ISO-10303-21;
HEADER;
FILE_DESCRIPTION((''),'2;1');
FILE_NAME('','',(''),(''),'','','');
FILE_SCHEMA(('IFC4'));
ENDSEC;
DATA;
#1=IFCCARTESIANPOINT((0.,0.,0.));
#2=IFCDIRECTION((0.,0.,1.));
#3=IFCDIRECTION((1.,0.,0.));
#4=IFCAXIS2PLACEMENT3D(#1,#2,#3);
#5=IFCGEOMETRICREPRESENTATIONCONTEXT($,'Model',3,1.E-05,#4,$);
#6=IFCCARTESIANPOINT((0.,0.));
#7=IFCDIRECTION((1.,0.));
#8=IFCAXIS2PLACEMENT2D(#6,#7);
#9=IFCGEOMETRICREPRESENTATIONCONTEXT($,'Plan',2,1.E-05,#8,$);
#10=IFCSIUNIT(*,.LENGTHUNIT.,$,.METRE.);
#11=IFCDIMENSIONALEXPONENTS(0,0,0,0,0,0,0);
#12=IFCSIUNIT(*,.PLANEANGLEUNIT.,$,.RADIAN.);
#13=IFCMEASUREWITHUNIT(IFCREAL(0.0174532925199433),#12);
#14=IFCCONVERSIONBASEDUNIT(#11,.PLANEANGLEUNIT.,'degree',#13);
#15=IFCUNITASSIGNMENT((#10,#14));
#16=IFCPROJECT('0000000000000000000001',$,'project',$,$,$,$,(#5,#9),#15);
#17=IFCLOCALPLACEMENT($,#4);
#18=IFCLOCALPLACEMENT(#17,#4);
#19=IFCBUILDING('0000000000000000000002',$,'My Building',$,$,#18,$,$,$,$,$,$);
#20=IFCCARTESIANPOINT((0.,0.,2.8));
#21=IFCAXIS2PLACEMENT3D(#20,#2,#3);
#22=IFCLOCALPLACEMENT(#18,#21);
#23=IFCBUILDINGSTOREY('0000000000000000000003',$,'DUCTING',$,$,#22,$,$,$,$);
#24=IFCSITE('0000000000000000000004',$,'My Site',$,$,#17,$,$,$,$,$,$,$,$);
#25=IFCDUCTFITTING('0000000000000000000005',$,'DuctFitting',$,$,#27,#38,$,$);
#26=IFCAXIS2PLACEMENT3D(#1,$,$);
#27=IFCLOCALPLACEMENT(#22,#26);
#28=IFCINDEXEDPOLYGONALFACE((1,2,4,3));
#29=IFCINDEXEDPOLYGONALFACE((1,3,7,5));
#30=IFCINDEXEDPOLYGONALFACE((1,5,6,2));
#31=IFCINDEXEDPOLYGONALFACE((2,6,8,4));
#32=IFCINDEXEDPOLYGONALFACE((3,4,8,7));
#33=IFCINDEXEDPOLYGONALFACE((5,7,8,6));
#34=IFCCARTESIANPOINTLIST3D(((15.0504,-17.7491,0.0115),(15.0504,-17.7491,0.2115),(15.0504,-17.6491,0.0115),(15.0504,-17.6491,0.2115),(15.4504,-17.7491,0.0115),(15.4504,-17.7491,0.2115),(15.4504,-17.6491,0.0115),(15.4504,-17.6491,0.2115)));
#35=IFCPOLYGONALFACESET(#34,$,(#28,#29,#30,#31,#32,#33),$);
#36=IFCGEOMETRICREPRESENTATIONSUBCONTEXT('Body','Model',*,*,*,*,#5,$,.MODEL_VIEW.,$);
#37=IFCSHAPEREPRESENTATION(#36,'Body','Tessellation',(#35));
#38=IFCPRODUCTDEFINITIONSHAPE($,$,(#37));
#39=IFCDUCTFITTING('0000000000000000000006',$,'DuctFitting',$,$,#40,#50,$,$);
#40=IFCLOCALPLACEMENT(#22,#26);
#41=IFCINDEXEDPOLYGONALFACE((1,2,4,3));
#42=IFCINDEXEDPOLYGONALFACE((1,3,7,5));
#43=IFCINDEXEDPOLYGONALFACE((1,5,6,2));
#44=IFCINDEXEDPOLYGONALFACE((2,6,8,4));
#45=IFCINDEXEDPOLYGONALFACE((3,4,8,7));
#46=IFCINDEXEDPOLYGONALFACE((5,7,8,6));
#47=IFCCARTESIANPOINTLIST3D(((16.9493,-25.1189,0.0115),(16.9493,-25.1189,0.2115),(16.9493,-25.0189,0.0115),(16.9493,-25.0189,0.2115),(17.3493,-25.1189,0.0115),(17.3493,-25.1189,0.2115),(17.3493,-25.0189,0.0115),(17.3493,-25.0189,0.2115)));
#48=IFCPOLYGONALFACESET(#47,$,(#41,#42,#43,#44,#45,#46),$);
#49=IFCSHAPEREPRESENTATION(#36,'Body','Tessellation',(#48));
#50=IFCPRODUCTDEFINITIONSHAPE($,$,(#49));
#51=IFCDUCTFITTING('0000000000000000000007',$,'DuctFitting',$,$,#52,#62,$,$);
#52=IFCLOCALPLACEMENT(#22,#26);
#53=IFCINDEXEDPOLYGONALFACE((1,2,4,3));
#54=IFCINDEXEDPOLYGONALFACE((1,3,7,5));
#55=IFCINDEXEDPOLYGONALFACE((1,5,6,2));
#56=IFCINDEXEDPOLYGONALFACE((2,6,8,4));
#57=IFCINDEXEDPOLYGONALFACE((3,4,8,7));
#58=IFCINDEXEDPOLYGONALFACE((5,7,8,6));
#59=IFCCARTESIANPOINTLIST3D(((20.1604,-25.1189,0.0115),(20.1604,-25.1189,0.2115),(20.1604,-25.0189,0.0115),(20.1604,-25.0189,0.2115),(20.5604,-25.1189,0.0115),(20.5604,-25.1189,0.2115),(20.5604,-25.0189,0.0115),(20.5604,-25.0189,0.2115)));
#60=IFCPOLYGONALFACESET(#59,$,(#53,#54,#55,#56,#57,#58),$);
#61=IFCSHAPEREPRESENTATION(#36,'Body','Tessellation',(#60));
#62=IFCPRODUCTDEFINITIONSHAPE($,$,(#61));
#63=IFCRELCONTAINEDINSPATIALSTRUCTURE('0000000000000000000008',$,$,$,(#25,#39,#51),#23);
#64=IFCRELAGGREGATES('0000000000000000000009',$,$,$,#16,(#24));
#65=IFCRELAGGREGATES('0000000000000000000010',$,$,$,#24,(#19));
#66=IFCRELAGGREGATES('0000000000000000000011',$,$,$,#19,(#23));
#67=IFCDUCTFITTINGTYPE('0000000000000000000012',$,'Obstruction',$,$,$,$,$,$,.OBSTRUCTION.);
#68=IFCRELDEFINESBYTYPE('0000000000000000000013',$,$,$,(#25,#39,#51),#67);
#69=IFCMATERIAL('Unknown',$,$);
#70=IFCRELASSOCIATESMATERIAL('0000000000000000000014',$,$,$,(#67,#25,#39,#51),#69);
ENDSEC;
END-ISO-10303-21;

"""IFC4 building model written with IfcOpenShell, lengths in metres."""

from ifc_helpers import new_model, entity, si_unit, converted_unit, frame, origin_with_axes, origin_2d_with_axis, place, context, subcontext, project, spatial, rectangle, extrude, material, material_profile, profile_set, profile_usage, type_object, element, save


model = new_model("IFC4")

# Units and contexts
model_context = context("Model", 3, precision=1e-05, world=origin_with_axes())
plan_context = context("Plan", 2, precision=1e-05, world=origin_2d_with_axis())
body_context = subcontext(model_context, "Body", "Model", "MODEL_VIEW")
ifc_project = project(units=[si_unit("LENGTHUNIT", "METRE"), converted_unit("PLANEANGLEUNIT", "degree", entity("IfcReal", 0.0174532925199433), si_unit("PLANEANGLEUNIT", "RADIAN"), dimensions=[0, 0, 0, 0, 0, 0, 0])], contexts=[model_context, plan_context])

# Site, building, storey
site_placement = place(None, origin_with_axes())
site = spatial("IfcSite", under=ifc_project, at=site_placement, Name="My Site")
building_placement = place(site_placement, origin_with_axes())
building = spatial("IfcBuilding", under=site, at=building_placement, Name="My Building")
storey_placement = place(building_placement, frame((0.0, 0.0, 2.8), z_axis=(0.0, 0.0, 1.0), x_axis=(1.0, 0.0, 0.0)))
storey = spatial("IfcBuildingStorey", under=building, at=storey_placement, Name="DUCTING")

# Shared definitions
ifc_material = material(Name="Unknown")

# Duct fittings
ifc_material_profile_1 = material_profile(ifc_material, rectangle(XDim=0.4, YDim=0.2))
ifc_profile_set_1 = profile_set([ifc_material_profile_1])
duct_fitting_type_1 = type_object("IfcDuctFittingType", Name="Obstruction", PredefinedType="OBSTRUCTION", material=ifc_profile_set_1)
ifc_profile_usage_1 = profile_usage(ifc_profile_set_1, cardinal=5)
duct_fitting_1_placement = place(storey_placement, frame((15.2504, -17.6491, 0.1115), z_axis=(0.0, -1.0, 0.0), x_axis=(1.0, 0.0, 0.0)))
element("IfcDuctFitting", 1, at=duct_fitting_1_placement, inside=storey, type_object=duct_fitting_type_1, material=ifc_profile_usage_1, Name="DuctFitting", context=body_context, shape_type="SweptSolid", body=[
    extrude(rectangle(XDim=0.4, YDim=0.2), origin_with_axes(), (0.0, 0.0, 1.0), 0.1),
])
ifc_profile_usage_2 = profile_usage(ifc_profile_set_1, cardinal=5)
duct_fitting_2_placement = place(storey_placement, frame((17.1493, -25.0189, 0.1115), z_axis=(0.000001, -1.0, 0.0), x_axis=(1.0, 0.000001, 0.0)))
element("IfcDuctFitting", 2, at=duct_fitting_2_placement, inside=storey, type_object=duct_fitting_type_1, material=ifc_profile_usage_2, Name="DuctFitting", context=body_context, shape_type="SweptSolid", body=[
    extrude(rectangle(XDim=0.4, YDim=0.2), origin_with_axes(), (0.0, 0.0, 1.0), 0.1),
])
ifc_profile_usage_3 = profile_usage(ifc_profile_set_1, cardinal=5)
duct_fitting_3_placement = place(storey_placement, frame((20.3604, -25.0189, 0.1115), z_axis=(0.000001, -1.0, 0.0), x_axis=(1.0, 0.000001, 0.0)))
element("IfcDuctFitting", 3, at=duct_fitting_3_placement, inside=storey, type_object=duct_fitting_type_1, material=ifc_profile_usage_3, Name="DuctFitting", context=body_context, shape_type="SweptSolid", body=[
    extrude(rectangle(XDim=0.4, YDim=0.2), origin_with_axes(), (0.0, 0.0, 1.0), 0.1),
])

save(model, "model.ifc")
